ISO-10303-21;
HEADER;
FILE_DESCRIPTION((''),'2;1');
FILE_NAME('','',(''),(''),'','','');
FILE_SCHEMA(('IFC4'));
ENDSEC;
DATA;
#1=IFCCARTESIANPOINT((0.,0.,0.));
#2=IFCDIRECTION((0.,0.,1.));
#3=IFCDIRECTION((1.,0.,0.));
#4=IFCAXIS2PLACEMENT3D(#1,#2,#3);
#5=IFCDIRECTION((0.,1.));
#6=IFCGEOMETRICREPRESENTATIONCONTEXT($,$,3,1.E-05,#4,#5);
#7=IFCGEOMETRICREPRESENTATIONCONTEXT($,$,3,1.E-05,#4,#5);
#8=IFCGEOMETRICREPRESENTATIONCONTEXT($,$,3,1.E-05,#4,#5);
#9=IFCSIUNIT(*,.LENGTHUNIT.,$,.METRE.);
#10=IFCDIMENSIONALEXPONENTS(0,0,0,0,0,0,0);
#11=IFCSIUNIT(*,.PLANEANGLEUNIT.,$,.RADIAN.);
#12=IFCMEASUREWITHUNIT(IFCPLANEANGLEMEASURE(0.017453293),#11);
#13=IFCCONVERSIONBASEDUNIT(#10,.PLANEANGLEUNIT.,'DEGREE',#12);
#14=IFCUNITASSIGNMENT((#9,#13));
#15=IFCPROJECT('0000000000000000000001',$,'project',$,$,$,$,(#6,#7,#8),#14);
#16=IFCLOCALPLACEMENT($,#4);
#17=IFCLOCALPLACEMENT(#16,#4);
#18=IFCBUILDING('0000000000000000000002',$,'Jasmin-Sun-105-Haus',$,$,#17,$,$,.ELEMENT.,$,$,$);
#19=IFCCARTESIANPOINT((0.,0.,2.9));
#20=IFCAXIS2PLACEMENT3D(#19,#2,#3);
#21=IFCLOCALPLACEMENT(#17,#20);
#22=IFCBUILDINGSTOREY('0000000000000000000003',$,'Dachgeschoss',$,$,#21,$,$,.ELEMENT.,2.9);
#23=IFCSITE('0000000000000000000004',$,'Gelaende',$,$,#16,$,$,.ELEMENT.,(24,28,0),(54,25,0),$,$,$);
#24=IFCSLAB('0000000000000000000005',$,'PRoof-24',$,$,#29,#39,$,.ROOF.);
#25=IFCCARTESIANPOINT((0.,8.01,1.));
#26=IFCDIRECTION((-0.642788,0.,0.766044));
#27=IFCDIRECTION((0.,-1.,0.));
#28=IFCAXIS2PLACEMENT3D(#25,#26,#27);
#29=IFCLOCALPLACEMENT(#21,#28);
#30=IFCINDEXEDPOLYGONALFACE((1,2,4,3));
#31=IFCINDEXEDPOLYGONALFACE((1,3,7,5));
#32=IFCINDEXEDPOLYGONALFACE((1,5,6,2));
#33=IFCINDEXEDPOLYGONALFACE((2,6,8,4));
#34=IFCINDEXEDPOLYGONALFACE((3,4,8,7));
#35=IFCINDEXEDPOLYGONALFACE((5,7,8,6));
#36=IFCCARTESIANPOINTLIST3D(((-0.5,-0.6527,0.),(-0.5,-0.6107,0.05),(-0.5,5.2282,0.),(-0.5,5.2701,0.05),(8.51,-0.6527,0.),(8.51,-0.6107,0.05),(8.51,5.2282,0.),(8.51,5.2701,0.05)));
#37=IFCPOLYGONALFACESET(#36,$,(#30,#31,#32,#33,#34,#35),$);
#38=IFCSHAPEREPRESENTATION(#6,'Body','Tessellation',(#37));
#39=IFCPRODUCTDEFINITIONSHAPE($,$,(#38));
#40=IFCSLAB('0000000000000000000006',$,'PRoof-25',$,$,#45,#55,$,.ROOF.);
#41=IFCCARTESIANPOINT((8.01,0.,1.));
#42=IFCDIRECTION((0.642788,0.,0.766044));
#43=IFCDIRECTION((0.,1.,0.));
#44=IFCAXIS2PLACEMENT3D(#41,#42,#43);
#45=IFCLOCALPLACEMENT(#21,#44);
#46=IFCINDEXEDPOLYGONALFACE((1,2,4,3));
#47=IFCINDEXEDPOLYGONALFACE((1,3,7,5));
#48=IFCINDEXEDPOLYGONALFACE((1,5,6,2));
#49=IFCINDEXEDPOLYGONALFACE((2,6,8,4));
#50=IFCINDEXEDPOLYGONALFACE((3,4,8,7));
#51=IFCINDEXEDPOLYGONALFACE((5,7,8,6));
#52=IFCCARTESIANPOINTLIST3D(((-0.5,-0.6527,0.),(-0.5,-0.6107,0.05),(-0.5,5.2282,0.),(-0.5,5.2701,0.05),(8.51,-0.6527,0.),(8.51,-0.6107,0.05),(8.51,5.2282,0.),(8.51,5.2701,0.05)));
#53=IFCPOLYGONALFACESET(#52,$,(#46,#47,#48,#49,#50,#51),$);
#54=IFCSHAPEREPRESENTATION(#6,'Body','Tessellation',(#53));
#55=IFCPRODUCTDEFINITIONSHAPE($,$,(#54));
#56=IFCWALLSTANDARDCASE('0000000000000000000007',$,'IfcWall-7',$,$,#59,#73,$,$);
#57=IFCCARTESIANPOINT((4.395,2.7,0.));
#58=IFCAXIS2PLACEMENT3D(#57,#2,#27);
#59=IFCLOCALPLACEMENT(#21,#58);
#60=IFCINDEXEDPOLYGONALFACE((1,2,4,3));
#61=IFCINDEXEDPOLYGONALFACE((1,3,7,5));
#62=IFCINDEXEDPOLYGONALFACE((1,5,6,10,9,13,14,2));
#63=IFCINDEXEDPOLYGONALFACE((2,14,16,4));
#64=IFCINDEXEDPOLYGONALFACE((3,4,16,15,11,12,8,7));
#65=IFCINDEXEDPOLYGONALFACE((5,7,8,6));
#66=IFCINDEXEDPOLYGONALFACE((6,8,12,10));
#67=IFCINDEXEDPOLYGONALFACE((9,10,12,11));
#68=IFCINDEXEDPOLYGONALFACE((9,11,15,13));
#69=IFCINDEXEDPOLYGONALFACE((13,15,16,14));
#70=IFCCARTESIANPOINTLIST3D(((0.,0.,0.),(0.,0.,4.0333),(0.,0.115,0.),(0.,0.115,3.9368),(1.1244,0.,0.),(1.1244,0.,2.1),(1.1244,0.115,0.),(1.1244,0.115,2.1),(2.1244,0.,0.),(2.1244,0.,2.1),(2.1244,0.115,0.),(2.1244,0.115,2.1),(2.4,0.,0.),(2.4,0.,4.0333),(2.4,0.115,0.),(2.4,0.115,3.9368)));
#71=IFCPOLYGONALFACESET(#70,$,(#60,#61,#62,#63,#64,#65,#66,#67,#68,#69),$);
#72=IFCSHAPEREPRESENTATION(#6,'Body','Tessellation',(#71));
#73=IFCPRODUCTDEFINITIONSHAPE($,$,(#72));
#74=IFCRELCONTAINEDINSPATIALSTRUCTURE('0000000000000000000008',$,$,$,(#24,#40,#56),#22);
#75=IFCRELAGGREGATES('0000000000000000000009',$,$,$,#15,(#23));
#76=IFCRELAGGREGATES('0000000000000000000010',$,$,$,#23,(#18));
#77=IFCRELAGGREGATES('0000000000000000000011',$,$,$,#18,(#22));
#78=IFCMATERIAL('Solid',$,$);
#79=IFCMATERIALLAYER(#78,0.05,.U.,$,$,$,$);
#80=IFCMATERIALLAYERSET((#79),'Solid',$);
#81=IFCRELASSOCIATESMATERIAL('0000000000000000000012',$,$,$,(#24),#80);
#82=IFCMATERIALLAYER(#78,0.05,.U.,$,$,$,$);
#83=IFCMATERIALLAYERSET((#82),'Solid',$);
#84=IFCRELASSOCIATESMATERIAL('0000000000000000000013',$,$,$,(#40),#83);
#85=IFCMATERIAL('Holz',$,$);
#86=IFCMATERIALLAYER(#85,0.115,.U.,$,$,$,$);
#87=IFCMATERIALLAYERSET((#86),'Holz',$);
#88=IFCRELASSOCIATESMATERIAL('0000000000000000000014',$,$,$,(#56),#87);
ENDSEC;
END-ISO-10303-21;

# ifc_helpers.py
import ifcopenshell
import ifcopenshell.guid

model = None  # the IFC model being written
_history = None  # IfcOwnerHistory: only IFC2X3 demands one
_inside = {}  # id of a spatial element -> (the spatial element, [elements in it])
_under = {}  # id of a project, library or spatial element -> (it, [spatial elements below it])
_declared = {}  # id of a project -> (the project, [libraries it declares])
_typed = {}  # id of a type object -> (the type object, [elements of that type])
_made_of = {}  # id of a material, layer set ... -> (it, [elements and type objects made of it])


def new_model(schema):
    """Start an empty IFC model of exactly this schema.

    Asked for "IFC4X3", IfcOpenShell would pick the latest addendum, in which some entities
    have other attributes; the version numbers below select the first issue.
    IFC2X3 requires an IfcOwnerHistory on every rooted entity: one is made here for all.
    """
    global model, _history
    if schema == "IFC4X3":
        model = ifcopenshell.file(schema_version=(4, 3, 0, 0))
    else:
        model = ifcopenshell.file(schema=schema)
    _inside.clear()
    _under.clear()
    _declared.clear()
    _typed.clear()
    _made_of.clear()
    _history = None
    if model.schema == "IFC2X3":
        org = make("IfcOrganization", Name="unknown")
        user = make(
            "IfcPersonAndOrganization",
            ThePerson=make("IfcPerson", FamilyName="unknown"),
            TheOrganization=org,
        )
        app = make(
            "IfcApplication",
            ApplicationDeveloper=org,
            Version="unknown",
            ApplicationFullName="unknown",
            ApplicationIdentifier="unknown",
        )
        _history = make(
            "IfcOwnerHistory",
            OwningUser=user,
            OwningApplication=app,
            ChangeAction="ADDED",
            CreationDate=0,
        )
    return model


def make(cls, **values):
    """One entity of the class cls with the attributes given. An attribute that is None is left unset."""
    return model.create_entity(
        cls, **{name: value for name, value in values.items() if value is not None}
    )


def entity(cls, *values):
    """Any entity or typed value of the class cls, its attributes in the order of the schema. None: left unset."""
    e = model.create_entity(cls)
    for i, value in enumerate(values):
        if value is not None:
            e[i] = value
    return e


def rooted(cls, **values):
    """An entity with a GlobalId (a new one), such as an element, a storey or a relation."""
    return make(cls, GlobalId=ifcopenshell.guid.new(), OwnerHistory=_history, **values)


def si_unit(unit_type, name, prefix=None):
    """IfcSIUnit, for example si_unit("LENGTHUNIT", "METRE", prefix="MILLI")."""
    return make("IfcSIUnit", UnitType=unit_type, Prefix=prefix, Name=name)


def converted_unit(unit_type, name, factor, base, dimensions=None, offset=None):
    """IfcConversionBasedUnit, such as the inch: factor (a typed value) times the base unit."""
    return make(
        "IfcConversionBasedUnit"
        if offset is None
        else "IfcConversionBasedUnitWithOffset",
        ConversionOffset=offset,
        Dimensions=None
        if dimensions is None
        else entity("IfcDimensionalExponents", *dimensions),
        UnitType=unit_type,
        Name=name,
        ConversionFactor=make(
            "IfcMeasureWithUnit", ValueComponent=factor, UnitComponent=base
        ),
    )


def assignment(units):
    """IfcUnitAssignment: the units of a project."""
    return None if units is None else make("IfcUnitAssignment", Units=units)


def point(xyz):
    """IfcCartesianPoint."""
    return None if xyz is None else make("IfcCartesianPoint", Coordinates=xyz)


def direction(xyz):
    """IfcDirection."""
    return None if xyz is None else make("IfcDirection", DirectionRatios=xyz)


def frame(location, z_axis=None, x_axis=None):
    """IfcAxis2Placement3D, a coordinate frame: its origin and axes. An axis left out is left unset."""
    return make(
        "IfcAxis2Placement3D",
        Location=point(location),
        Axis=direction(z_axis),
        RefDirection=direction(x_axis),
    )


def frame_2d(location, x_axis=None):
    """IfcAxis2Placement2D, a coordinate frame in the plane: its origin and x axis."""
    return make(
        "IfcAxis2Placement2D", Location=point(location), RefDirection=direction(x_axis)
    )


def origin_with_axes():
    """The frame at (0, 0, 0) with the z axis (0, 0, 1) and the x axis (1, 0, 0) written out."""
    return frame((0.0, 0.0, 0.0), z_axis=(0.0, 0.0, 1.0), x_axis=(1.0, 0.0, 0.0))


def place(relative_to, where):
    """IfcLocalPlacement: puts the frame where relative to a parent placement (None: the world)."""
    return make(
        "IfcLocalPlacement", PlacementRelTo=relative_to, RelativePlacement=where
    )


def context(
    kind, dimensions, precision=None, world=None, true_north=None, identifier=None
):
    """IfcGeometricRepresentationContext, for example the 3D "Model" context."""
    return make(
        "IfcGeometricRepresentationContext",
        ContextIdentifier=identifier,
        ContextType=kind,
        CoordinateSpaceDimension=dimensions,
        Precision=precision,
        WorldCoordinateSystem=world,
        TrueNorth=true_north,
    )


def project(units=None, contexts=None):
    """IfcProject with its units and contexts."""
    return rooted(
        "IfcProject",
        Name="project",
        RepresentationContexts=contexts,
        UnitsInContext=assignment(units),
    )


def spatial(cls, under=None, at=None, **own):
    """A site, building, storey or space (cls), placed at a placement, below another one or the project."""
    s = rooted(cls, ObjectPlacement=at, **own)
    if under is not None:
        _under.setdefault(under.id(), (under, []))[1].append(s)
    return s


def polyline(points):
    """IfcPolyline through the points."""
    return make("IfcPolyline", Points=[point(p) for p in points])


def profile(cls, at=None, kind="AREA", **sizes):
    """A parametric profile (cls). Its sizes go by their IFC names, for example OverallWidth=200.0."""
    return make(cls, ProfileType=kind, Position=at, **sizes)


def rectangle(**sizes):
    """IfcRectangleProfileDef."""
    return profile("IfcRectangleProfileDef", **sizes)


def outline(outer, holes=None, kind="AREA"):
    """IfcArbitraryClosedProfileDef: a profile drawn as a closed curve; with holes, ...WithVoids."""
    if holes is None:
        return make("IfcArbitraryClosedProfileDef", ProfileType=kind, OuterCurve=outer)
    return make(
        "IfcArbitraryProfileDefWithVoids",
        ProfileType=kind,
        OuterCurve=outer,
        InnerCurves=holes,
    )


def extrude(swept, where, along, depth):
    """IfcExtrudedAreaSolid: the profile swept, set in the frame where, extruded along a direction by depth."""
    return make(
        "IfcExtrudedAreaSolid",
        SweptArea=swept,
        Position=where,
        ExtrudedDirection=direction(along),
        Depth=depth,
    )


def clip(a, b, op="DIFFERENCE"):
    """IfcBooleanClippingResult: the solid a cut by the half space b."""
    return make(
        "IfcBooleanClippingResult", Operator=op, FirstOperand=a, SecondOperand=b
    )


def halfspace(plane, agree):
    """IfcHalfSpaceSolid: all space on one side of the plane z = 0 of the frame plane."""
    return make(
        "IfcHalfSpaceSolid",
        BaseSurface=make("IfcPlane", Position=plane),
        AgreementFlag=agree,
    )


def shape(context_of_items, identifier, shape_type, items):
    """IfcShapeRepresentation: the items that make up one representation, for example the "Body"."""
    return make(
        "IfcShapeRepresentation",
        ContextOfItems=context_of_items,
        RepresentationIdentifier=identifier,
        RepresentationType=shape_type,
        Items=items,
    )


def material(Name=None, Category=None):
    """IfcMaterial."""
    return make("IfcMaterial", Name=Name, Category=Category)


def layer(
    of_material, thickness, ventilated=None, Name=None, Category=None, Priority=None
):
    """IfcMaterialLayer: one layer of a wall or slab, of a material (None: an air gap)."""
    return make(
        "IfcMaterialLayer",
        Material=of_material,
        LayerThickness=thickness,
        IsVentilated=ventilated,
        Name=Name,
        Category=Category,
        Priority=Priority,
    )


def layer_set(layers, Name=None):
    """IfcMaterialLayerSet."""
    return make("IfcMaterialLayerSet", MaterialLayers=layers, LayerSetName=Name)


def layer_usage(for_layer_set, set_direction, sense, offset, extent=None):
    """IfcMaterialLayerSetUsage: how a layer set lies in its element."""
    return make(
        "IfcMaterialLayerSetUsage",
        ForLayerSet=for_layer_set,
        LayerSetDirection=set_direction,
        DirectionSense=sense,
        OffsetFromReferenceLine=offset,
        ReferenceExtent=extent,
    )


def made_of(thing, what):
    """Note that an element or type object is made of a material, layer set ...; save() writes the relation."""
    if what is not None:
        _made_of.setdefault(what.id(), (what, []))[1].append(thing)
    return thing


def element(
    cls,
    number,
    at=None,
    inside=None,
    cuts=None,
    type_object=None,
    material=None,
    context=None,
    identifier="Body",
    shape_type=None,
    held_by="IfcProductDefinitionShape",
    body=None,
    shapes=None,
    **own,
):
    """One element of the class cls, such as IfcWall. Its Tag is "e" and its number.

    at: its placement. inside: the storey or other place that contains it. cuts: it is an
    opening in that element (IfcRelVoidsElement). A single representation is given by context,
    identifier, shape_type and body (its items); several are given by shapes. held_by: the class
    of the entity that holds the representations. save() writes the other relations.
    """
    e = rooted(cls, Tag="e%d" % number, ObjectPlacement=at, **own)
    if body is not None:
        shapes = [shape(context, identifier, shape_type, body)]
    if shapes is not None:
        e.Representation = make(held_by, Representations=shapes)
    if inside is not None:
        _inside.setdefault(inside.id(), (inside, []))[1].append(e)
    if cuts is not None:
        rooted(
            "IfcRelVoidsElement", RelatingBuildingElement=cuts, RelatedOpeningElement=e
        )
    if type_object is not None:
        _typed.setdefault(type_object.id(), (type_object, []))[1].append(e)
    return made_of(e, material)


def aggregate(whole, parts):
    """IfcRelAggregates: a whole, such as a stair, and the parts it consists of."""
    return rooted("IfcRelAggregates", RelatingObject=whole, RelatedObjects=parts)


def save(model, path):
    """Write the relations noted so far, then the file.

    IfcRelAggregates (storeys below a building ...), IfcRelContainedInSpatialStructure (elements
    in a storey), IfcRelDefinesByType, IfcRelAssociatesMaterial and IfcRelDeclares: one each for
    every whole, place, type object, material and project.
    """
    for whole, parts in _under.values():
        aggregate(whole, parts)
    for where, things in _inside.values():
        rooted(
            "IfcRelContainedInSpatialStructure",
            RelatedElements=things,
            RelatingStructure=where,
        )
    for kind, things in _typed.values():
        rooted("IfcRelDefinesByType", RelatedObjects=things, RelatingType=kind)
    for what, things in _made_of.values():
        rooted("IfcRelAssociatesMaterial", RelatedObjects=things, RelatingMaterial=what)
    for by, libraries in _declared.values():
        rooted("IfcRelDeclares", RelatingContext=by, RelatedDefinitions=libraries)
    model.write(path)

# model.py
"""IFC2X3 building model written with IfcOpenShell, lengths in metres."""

from ifc_helpers import new_model, entity, si_unit, converted_unit, direction, frame, frame_2d, origin_with_axes, place, context, project, spatial, polyline, rectangle, outline, extrude, clip, halfspace, material, layer, layer_set, layer_usage, element, save


model = new_model("IFC2X3")

# Units and contexts
context_of_model_1 = context(None, 3, precision=1e-05, world=origin_with_axes(), true_north=direction((0.0, 1.0)))
context_of_model_2 = context(None, 3, precision=1e-05, world=origin_with_axes(), true_north=direction((0.0, 1.0)))
context_of_model_3 = context(None, 3, precision=1e-05, world=origin_with_axes(), true_north=direction((0.0, 1.0)))
ifc_project = project(units=[si_unit("LENGTHUNIT", "METRE"), converted_unit("PLANEANGLEUNIT", "DEGREE", entity("IfcPlaneAngleMeasure", 0.017453293), si_unit("PLANEANGLEUNIT", "RADIAN"), dimensions=[0, 0, 0, 0, 0, 0, 0])], contexts=[context_of_model_1, context_of_model_2, context_of_model_3])

# Site, building, storey
site_placement = place(None, origin_with_axes())
site = spatial("IfcSite", under=ifc_project, at=site_placement, Name="Gelaende", CompositionType="ELEMENT", RefLatitude=(24, 28, 0), RefLongitude=(54, 25, 0))
building_placement = place(site_placement, origin_with_axes())
building = spatial("IfcBuilding", under=site, at=building_placement, Name="Jasmin-Sun-105-Haus", CompositionType="ELEMENT")
storey_placement = place(building_placement, frame((0.0, 0.0, 2.9), z_axis=(0.0, 0.0, 1.0), x_axis=(1.0, 0.0, 0.0)))
storey = spatial("IfcBuildingStorey", under=building, at=storey_placement, Name="Dachgeschoss", CompositionType="ELEMENT", Elevation=2.9)

# Shared definitions
ifc_material_1 = material(Name="Solid")

# Slabs
ifc_layer_1 = layer(ifc_material_1, 0.05, ventilated="UNKNOWN")
ifc_layer_set_1 = layer_set([ifc_layer_1], Name="Solid")
ifc_layer_usage_1 = layer_usage(ifc_layer_set_1, "AXIS3", "NEGATIVE", 0.05)
slab_1_placement = place(storey_placement, frame((0.0, 8.01, 1.0), z_axis=(-0.642788, 0.0, 0.766044), x_axis=(0.0, -1.0, 0.0)))
element("IfcSlab", 1, at=slab_1_placement, inside=storey, material=ifc_layer_usage_1, Name="PRoof-24", PredefinedType="ROOF", context=context_of_model_1, shape_type="SweptSolid", body=[
    extrude(outline(polyline([(8.51, -0.6527), (-0.5, -0.6527), (-0.5, 5.2282), (8.51, 5.2282), (8.51, -0.6527)])), origin_with_axes(), (0.0, 0.642788, 0.766044), 0.0653),
])
ifc_layer_2 = layer(ifc_material_1, 0.05, ventilated="UNKNOWN")
ifc_layer_set_2 = layer_set([ifc_layer_2], Name="Solid")
ifc_layer_usage_2 = layer_usage(ifc_layer_set_2, "AXIS3", "NEGATIVE", 0.05)
slab_2_placement = place(storey_placement, frame((8.01, 0.0, 1.0), z_axis=(0.642788, 0.0, 0.766044), x_axis=(0.0, 1.0, 0.0)))
element("IfcSlab", 2, at=slab_2_placement, inside=storey, material=ifc_layer_usage_2, Name="PRoof-25", PredefinedType="ROOF", context=context_of_model_1, shape_type="SweptSolid", body=[
    extrude(outline(polyline([(8.51, 5.2282), (8.51, -0.6527), (-0.5, -0.6527), (-0.5, 5.2282), (8.51, 5.2282)])), origin_with_axes(), (0.0, 0.642788, 0.766044), 0.0653),
])

# Wall, opening
ifc_material_2 = material(Name="Holz")
ifc_layer_3 = layer(ifc_material_2, 0.115, ventilated="UNKNOWN")
ifc_layer_set_3 = layer_set([ifc_layer_3], Name="Holz")
ifc_layer_usage_3 = layer_usage(ifc_layer_set_3, "AXIS2", "POSITIVE", 0.0)
wall_1_placement = place(storey_placement, frame((4.395, 2.7, 0.0), z_axis=(0.0, 0.0, 1.0), x_axis=(0.0, -1.0, 0.0)))
wall_1 = element("IfcWallStandardCase", 3, at=wall_1_placement, inside=storey, material=ifc_layer_usage_3, Name="IfcWall-7", context=context_of_model_1, shape_type="Clipping", body=[
    clip(clip(extrude(outline(polyline([(0.0, 0.0), (2.4, 0.0), (2.4, 0.115), (0.0, 0.115), (0.0, 0.0)])), origin_with_axes(), (0.0, 0.0, 1.0), 5.0), halfspace(frame((0.0, 1.986, 2.3669), z_axis=(0.0, 0.642788, 0.766044), x_axis=(0.0, 0.766044, -0.642788)), False)), halfspace(frame((0.0, 2.1472, 2.5589), z_axis=(0.0, 0.642788, 0.766044), x_axis=(0.0, 0.766044, -0.642788)), False)),
])
opening_1_placement = place(wall_1_placement, frame((1.6244, 0.0, 0.0), z_axis=(0.0, 0.0, 1.0), x_axis=(1.0, 0.0, 0.0)))
element("IfcOpeningElement", 4, at=opening_1_placement, cuts=wall_1, context=context_of_model_1, shape_type="SweptSolid", body=[
    extrude(rectangle(XDim=2.1, YDim=1.0, at=frame_2d((0.0, 1.05), x_axis=(0.0, -1.0))), frame((0.0, 0.0, 0.0), z_axis=(0.0, 1.0, 0.0), x_axis=(-1.0, 0.0, 0.0)), (0.0, 0.0, 1.0), 0.115),
])

save(model, "model.ifc")
